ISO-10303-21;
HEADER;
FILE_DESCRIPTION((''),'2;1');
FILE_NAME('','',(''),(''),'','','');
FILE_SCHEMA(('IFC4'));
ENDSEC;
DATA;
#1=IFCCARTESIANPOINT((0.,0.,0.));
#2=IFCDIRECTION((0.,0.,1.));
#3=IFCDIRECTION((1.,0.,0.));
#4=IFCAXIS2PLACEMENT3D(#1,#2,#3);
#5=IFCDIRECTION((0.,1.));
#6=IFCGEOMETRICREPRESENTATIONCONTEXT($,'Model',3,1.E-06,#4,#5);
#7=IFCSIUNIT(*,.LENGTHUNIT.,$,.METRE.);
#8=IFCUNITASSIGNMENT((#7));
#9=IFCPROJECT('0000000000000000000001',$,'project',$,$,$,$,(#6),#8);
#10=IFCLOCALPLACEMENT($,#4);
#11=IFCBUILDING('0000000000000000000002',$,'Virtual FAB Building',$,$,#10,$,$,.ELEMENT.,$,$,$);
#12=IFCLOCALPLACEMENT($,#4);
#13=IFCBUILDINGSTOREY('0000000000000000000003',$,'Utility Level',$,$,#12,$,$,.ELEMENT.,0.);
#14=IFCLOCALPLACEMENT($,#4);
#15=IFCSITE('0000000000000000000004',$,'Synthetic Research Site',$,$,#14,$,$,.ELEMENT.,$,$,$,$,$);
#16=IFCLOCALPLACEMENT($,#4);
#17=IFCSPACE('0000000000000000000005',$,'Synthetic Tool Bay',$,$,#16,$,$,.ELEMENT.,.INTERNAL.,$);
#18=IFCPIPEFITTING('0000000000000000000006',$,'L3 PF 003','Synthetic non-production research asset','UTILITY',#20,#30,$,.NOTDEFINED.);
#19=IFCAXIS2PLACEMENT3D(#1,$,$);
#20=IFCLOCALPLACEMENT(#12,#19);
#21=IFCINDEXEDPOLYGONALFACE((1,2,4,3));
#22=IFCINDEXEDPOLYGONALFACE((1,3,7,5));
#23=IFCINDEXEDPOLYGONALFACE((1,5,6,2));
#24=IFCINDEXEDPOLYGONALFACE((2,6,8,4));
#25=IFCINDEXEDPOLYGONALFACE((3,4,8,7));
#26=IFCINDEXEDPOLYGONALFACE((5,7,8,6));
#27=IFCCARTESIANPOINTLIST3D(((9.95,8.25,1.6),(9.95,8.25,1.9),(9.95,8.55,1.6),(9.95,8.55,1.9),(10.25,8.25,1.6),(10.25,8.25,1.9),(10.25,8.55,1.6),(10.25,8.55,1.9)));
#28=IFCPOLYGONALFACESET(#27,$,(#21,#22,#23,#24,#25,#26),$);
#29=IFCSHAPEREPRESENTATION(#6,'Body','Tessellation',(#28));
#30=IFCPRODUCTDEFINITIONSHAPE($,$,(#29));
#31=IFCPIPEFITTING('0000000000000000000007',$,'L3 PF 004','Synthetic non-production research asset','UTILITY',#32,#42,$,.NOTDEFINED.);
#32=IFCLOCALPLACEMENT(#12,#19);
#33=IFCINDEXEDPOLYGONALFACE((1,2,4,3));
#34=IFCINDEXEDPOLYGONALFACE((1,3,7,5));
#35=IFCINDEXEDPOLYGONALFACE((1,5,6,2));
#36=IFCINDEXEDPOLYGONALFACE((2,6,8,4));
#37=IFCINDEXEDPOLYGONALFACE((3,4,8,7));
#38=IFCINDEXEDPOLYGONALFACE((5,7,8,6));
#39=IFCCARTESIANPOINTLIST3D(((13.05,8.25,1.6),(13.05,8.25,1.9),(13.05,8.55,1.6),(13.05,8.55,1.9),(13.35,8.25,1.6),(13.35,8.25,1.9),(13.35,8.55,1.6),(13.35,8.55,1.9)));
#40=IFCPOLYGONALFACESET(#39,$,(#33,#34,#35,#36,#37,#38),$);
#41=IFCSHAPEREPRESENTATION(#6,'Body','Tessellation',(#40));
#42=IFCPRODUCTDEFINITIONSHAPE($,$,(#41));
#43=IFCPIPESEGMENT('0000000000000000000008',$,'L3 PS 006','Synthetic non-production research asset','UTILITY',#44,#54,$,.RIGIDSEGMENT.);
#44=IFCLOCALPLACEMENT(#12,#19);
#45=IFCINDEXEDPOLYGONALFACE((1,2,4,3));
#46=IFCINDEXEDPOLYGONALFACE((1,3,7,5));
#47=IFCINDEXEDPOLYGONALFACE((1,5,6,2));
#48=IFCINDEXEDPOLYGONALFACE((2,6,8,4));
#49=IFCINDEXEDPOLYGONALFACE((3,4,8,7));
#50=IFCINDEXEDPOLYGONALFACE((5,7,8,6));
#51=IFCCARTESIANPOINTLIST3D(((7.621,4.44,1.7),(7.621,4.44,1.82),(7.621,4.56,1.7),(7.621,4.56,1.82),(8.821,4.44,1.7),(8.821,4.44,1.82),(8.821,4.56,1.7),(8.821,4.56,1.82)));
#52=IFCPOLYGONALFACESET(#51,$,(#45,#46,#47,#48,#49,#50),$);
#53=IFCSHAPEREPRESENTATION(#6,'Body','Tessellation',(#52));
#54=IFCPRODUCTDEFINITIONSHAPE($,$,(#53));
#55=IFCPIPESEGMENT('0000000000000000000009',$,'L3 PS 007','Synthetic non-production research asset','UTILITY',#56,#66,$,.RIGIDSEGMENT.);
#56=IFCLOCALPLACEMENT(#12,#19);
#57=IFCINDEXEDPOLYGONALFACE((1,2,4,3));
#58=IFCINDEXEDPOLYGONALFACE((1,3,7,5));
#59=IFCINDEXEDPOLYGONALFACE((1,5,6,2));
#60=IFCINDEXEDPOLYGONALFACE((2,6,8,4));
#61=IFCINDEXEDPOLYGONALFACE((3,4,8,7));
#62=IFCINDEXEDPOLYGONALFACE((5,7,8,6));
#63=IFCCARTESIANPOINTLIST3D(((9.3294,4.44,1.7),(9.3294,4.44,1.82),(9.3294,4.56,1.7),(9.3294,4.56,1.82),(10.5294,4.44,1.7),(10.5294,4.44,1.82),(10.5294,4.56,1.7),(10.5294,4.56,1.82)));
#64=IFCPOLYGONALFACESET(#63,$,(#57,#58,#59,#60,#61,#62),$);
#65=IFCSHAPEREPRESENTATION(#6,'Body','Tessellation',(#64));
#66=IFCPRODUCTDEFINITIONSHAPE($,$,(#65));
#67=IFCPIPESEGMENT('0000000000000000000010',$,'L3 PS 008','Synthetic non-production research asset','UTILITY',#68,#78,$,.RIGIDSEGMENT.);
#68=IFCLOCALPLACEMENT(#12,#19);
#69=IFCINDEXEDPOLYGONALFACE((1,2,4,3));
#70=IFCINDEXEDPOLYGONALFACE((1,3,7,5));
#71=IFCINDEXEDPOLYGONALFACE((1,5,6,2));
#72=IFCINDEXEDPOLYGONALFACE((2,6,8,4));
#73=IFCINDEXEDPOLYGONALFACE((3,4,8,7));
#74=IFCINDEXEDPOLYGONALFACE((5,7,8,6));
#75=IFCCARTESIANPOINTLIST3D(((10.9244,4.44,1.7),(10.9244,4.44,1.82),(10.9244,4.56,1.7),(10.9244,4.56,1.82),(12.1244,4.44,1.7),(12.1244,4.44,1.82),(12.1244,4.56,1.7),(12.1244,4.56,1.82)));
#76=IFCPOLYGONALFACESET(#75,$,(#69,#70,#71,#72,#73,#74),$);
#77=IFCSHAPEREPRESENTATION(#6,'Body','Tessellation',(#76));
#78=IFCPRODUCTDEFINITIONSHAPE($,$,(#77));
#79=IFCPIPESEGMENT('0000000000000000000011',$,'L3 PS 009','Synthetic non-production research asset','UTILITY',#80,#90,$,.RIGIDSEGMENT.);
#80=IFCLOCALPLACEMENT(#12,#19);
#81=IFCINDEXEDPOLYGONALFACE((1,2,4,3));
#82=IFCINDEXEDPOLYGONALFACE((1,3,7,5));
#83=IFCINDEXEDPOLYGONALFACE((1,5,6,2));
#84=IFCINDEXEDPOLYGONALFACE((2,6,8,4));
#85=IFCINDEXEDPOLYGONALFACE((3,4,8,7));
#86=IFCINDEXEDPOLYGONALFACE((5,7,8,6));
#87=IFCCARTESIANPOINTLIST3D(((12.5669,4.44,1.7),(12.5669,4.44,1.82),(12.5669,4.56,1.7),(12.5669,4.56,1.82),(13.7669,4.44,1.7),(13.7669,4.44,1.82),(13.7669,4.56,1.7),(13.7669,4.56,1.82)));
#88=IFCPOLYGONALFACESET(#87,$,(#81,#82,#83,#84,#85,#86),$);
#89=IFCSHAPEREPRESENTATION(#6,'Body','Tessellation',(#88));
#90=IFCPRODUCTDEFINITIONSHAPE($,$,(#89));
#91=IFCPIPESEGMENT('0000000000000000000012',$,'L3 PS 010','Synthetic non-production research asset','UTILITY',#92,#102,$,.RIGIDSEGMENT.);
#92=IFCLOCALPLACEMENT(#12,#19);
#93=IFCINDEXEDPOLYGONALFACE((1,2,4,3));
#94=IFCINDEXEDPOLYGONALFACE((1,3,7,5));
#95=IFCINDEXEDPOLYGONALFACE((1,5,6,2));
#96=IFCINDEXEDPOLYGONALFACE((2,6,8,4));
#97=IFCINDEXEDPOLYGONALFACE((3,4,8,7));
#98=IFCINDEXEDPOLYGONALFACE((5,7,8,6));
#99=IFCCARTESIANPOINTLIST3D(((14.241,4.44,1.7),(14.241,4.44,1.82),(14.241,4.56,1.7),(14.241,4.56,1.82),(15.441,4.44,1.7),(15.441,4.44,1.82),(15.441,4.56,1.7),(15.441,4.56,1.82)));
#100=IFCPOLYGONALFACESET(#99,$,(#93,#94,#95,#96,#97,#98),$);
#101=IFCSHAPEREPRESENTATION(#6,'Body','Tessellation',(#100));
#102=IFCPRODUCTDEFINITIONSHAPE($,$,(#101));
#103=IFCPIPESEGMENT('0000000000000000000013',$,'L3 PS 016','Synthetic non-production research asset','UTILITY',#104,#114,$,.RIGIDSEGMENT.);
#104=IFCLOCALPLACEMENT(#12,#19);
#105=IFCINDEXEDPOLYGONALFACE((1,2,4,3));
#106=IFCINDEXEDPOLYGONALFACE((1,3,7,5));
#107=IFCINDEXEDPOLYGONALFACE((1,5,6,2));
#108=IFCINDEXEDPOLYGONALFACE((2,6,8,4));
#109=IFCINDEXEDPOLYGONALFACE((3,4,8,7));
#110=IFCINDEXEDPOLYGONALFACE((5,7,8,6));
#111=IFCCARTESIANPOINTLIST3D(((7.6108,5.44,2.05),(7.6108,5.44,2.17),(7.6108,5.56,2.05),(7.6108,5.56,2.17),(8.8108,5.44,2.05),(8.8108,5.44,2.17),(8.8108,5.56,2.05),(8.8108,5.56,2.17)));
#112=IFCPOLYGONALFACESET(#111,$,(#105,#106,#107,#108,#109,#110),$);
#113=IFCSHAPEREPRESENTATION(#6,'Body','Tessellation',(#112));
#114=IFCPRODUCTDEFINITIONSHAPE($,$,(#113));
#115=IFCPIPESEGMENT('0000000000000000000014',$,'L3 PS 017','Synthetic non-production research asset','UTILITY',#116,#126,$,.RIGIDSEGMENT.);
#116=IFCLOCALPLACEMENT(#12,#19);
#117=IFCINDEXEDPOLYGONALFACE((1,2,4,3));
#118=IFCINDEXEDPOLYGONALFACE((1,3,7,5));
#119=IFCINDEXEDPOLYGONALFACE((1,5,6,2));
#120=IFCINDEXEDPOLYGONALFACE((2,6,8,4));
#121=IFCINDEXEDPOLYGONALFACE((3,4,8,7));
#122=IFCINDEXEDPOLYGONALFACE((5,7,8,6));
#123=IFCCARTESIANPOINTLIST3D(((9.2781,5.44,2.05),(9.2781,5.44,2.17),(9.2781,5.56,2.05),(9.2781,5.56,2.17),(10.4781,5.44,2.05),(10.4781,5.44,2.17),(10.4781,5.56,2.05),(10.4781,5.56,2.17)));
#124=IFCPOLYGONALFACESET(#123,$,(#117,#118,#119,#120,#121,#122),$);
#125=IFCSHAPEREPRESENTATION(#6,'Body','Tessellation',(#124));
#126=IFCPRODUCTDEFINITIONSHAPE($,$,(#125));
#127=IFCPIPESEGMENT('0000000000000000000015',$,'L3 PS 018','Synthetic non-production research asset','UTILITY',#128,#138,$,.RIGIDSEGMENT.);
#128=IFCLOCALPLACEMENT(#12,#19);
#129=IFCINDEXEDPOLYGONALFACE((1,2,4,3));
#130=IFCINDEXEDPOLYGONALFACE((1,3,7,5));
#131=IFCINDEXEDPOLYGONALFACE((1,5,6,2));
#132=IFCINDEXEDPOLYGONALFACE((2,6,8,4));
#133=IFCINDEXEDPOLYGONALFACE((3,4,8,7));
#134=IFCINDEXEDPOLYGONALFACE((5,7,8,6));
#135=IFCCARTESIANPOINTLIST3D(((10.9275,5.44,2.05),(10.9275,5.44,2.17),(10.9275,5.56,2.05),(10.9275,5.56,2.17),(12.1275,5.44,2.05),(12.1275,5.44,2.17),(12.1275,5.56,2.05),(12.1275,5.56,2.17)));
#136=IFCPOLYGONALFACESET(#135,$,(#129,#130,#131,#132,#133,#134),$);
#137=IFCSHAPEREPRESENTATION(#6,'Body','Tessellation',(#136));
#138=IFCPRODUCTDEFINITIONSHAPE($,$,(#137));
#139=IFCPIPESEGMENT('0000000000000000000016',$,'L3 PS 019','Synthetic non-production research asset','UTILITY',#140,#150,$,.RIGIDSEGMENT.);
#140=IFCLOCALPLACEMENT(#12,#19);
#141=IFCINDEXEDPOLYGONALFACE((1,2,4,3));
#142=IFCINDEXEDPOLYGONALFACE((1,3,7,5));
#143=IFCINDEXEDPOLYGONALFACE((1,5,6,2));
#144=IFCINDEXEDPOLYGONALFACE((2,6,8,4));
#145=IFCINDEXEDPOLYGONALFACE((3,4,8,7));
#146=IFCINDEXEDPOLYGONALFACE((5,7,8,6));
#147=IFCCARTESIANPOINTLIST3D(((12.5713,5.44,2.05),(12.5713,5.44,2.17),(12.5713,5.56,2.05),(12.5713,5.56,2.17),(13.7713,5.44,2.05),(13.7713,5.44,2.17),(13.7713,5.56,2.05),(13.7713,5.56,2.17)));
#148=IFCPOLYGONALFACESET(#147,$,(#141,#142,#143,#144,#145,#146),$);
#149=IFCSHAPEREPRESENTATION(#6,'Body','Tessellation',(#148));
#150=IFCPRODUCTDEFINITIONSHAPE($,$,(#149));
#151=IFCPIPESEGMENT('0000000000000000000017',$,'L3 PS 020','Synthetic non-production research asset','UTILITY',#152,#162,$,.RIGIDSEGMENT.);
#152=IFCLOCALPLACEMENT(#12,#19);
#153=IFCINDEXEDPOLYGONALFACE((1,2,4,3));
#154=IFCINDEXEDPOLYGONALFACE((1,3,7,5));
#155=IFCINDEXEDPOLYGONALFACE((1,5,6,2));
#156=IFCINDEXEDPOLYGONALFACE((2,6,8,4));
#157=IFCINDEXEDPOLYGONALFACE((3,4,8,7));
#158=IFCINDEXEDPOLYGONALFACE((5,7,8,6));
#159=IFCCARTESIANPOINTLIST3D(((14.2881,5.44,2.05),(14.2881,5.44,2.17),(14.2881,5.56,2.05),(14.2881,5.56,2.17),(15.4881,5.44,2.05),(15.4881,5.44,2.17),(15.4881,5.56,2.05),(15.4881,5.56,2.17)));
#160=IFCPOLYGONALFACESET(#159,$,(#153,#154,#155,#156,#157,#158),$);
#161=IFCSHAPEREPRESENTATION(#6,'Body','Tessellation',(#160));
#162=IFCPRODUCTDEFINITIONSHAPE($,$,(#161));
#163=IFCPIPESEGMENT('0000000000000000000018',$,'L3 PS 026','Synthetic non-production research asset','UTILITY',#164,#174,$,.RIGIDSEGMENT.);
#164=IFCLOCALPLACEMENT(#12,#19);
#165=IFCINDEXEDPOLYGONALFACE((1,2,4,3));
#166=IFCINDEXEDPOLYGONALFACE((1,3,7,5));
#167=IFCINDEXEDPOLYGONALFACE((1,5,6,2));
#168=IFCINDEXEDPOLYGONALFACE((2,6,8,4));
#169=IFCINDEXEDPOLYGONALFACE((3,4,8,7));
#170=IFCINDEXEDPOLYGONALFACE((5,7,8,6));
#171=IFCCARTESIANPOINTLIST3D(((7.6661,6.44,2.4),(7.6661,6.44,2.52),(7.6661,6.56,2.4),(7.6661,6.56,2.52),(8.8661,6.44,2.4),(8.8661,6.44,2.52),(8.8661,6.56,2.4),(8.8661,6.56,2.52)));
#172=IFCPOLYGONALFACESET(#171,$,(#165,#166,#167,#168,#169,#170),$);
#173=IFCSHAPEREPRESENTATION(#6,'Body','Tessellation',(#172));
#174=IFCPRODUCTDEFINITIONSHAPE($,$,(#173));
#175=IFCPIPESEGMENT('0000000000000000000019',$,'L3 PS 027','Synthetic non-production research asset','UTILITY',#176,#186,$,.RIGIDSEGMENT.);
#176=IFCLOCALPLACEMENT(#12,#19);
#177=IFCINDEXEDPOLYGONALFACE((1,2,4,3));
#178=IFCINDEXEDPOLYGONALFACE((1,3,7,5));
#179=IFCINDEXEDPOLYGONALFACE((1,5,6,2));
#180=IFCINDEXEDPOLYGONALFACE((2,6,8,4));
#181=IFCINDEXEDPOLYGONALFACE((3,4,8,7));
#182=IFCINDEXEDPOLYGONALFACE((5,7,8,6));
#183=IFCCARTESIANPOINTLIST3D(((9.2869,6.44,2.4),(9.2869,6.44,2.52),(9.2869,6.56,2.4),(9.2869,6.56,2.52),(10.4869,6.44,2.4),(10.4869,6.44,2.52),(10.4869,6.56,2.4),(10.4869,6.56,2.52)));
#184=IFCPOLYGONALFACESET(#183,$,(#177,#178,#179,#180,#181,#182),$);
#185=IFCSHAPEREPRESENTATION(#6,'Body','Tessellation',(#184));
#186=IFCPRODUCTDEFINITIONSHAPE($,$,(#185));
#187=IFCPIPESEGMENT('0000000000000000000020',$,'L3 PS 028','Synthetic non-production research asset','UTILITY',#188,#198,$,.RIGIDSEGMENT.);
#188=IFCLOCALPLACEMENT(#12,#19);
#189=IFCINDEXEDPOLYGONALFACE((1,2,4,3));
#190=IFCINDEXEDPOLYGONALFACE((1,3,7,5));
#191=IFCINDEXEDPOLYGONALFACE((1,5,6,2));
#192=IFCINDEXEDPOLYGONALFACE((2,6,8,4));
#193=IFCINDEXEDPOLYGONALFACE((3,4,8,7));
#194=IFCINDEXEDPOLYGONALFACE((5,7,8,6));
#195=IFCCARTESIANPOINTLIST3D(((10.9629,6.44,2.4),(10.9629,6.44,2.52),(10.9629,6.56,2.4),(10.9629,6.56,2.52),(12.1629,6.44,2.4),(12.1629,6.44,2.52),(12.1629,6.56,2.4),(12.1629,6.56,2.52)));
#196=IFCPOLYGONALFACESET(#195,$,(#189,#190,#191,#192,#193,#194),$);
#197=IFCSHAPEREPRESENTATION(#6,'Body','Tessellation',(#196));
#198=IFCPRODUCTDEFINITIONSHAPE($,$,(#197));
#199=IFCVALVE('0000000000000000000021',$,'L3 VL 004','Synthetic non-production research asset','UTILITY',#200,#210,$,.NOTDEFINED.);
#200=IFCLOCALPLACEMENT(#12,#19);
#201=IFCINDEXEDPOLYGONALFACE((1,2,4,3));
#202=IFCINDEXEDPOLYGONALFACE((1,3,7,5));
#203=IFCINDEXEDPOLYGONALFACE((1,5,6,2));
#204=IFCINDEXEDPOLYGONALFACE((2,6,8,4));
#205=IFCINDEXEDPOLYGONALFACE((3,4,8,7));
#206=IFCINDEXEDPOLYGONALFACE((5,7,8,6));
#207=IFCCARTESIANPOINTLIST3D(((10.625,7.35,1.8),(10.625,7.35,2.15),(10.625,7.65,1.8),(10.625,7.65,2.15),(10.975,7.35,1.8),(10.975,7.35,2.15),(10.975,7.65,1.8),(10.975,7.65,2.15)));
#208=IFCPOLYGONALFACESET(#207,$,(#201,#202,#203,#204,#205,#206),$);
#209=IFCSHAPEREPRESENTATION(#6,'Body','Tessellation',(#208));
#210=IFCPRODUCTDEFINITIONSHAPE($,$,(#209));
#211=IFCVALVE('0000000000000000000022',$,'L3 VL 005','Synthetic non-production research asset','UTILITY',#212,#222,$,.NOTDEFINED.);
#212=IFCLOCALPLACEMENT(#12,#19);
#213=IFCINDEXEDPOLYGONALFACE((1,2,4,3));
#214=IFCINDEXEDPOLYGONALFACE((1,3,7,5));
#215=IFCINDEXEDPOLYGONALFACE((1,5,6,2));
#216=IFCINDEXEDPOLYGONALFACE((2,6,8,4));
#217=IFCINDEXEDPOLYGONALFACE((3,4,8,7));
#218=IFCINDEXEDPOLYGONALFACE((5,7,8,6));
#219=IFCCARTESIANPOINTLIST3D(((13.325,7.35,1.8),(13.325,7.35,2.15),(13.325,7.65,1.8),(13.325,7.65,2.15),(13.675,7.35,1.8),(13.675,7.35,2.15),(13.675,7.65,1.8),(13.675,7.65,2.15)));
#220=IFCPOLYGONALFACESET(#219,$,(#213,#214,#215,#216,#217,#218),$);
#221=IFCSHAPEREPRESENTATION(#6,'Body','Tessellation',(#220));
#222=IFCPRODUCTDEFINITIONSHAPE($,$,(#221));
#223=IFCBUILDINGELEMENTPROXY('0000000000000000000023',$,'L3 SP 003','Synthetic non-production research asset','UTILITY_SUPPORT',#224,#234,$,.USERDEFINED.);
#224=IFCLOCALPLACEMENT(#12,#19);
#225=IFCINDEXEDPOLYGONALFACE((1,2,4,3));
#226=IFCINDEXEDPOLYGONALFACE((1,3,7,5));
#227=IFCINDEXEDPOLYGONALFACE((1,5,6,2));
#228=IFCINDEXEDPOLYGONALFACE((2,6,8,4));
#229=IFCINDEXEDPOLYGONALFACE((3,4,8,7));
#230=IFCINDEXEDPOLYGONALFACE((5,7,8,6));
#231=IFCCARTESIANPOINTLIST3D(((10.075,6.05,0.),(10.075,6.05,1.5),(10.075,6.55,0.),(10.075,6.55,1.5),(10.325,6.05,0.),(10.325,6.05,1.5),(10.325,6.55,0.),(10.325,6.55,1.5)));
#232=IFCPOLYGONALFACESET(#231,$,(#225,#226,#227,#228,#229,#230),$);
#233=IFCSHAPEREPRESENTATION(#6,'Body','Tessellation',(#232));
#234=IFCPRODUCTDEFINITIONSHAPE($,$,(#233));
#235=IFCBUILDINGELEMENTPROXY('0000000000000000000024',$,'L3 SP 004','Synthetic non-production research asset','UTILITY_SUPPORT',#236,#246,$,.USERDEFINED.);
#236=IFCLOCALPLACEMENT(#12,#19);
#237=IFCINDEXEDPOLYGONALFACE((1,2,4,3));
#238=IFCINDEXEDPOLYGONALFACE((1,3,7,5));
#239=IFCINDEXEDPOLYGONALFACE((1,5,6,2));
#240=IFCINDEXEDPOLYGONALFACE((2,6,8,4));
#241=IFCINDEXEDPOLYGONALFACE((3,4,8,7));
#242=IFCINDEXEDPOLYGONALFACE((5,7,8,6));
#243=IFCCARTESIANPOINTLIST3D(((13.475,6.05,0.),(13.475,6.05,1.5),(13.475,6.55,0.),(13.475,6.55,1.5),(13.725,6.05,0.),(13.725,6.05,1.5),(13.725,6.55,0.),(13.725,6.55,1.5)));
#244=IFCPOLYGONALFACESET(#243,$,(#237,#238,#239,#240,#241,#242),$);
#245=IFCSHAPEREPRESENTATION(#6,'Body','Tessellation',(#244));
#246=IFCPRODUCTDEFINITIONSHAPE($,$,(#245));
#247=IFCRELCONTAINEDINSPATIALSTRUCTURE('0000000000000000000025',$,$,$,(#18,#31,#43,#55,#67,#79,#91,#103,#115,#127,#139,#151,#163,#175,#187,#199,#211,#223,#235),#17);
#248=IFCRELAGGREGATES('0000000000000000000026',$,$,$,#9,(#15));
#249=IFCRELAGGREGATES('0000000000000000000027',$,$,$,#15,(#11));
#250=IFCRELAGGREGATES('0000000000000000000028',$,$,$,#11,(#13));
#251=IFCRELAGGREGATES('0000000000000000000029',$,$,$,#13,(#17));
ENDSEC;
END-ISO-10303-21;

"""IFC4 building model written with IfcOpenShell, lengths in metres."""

from ifc_helpers import new_model, si_unit, direction, frame, origin_with_axes, origin_2d_with_axis, place, context, project, spatial, rectangle, extrude, element, save


model = new_model("IFC4")

# Units and contexts
model_context = context("Model", 3, precision=1e-06, world=origin_with_axes(), true_north=direction((0.0, 1.0)))
ifc_project = project(units=[si_unit("LENGTHUNIT", "METRE")], contexts=[model_context])

# Site, building, storey, space
site_placement = place(None, origin_with_axes())
site = spatial("IfcSite", under=ifc_project, at=site_placement, Name="Synthetic Research Site", CompositionType="ELEMENT")
building_placement = place(None, origin_with_axes())
building = spatial("IfcBuilding", under=site, at=building_placement, Name="Virtual FAB Building", CompositionType="ELEMENT")
storey_placement = place(None, origin_with_axes())
storey = spatial("IfcBuildingStorey", under=building, at=storey_placement, Name="Utility Level", CompositionType="ELEMENT", Elevation=0.0)
space_placement = place(None, origin_with_axes())
space = spatial("IfcSpace", under=storey, at=space_placement, Name="Synthetic Tool Bay", CompositionType="ELEMENT", PredefinedType="INTERNAL")

# Pipe fittings
for number, where, z_axis, x_axis, name in (
    (1, (10.1, 8.4, 1.6), (0.0, 0.0, 1.0), (1.0, 0.0, 0.0), "L3 PF 003"),
    (2, (13.2, 8.4, 1.6), (0.0, 0.0, 1.0), (1.0, 0.0, 0.0), "L3 PF 004"),
):
    element("IfcPipeFitting", number, at=place(None, frame(where, z_axis=z_axis, x_axis=x_axis)), inside=space, Name=name, Description="Synthetic non-production research asset", ObjectType="UTILITY", PredefinedType="NOTDEFINED", context=model_context, shape_type="SweptSolid", body=[
        extrude(rectangle(XDim=0.3, YDim=0.3, at=origin_2d_with_axis()), origin_with_axes(), (0.0, 0.0, 1.0), 0.3),
    ])

# Pipe segments
for number, where, z_axis, x_axis, name in (
    (3, (8.221, 4.5, 1.7), (0.0, 0.0, 1.0), (1.0, 0.0, 0.0), "L3 PS 006"),
    (4, (9.9294, 4.5, 1.7), (0.0, 0.0, 1.0), (1.0, 0.0, 0.0), "L3 PS 007"),
    (5, (11.5244, 4.5, 1.7), (0.0, 0.0, 1.0), (1.0, 0.0, 0.0), "L3 PS 008"),
    (6, (13.1669, 4.5, 1.7), (0.0, 0.0, 1.0), (1.0, 0.0, 0.0), "L3 PS 009"),
    (7, (14.841, 4.5, 1.7), (0.0, 0.0, 1.0), (1.0, 0.0, 0.0), "L3 PS 010"),
    (8, (8.2108, 5.5, 2.05), (0.0, 0.0, 1.0), (1.0, 0.0, 0.0), "L3 PS 016"),
    (9, (9.8781, 5.5, 2.05), (0.0, 0.0, 1.0), (1.0, 0.0, 0.0), "L3 PS 017"),
    (10, (11.5275, 5.5, 2.05), (0.0, 0.0, 1.0), (1.0, 0.0, 0.0), "L3 PS 018"),
    (11, (13.1713, 5.5, 2.05), (0.0, 0.0, 1.0), (1.0, 0.0, 0.0), "L3 PS 019"),
    (12, (14.8881, 5.5, 2.05), (0.0, 0.0, 1.0), (1.0, 0.0, 0.0), "L3 PS 020"),
    (13, (8.2661, 6.5, 2.4), (0.0, 0.0, 1.0), (1.0, 0.0, 0.0), "L3 PS 026"),
    (14, (9.8869, 6.5, 2.4), (0.0, 0.0, 1.0), (1.0, 0.0, 0.0), "L3 PS 027"),
    (15, (11.5629, 6.5, 2.4), (0.0, 0.0, 1.0), (1.0, 0.0, 0.0), "L3 PS 028"),
):
    element("IfcPipeSegment", number, at=place(None, frame(where, z_axis=z_axis, x_axis=x_axis)), inside=space, Name=name, Description="Synthetic non-production research asset", ObjectType="UTILITY", PredefinedType="RIGIDSEGMENT", context=model_context, shape_type="SweptSolid", body=[
        extrude(rectangle(XDim=1.2, YDim=0.12, at=origin_2d_with_axis()), origin_with_axes(), (0.0, 0.0, 1.0), 0.12),
    ])

# Valves
for number, where, z_axis, x_axis, name in (
    (16, (10.8, 7.5, 1.8), (0.0, 0.0, 1.0), (1.0, 0.0, 0.0), "L3 VL 004"),
    (17, (13.5, 7.5, 1.8), (0.0, 0.0, 1.0), (1.0, 0.0, 0.0), "L3 VL 005"),
):
    element("IfcValve", number, at=place(None, frame(where, z_axis=z_axis, x_axis=x_axis)), inside=space, Name=name, Description="Synthetic non-production research asset", ObjectType="UTILITY", PredefinedType="NOTDEFINED", context=model_context, shape_type="SweptSolid", body=[
        extrude(rectangle(XDim=0.35, YDim=0.3, at=origin_2d_with_axis()), origin_with_axes(), (0.0, 0.0, 1.0), 0.35),
    ])

# Building element proxies
for number, where, z_axis, x_axis, name in (
    (18, (10.2, 6.3, 0.0), (0.0, 0.0, 1.0), (1.0, 0.0, 0.0), "L3 SP 003"),
    (19, (13.6, 6.3, 0.0), (0.0, 0.0, 1.0), (1.0, 0.0, 0.0), "L3 SP 004"),
):
    element("IfcBuildingElementProxy", number, at=place(None, frame(where, z_axis=z_axis, x_axis=x_axis)), inside=space, Name=name, Description="Synthetic non-production research asset", ObjectType="UTILITY_SUPPORT", PredefinedType="USERDEFINED", context=model_context, shape_type="SweptSolid", body=[
        extrude(rectangle(XDim=0.25, YDim=0.5, at=origin_2d_with_axis()), origin_with_axes(), (0.0, 0.0, 1.0), 1.5),
    ])

save(model, "model.ifc")
